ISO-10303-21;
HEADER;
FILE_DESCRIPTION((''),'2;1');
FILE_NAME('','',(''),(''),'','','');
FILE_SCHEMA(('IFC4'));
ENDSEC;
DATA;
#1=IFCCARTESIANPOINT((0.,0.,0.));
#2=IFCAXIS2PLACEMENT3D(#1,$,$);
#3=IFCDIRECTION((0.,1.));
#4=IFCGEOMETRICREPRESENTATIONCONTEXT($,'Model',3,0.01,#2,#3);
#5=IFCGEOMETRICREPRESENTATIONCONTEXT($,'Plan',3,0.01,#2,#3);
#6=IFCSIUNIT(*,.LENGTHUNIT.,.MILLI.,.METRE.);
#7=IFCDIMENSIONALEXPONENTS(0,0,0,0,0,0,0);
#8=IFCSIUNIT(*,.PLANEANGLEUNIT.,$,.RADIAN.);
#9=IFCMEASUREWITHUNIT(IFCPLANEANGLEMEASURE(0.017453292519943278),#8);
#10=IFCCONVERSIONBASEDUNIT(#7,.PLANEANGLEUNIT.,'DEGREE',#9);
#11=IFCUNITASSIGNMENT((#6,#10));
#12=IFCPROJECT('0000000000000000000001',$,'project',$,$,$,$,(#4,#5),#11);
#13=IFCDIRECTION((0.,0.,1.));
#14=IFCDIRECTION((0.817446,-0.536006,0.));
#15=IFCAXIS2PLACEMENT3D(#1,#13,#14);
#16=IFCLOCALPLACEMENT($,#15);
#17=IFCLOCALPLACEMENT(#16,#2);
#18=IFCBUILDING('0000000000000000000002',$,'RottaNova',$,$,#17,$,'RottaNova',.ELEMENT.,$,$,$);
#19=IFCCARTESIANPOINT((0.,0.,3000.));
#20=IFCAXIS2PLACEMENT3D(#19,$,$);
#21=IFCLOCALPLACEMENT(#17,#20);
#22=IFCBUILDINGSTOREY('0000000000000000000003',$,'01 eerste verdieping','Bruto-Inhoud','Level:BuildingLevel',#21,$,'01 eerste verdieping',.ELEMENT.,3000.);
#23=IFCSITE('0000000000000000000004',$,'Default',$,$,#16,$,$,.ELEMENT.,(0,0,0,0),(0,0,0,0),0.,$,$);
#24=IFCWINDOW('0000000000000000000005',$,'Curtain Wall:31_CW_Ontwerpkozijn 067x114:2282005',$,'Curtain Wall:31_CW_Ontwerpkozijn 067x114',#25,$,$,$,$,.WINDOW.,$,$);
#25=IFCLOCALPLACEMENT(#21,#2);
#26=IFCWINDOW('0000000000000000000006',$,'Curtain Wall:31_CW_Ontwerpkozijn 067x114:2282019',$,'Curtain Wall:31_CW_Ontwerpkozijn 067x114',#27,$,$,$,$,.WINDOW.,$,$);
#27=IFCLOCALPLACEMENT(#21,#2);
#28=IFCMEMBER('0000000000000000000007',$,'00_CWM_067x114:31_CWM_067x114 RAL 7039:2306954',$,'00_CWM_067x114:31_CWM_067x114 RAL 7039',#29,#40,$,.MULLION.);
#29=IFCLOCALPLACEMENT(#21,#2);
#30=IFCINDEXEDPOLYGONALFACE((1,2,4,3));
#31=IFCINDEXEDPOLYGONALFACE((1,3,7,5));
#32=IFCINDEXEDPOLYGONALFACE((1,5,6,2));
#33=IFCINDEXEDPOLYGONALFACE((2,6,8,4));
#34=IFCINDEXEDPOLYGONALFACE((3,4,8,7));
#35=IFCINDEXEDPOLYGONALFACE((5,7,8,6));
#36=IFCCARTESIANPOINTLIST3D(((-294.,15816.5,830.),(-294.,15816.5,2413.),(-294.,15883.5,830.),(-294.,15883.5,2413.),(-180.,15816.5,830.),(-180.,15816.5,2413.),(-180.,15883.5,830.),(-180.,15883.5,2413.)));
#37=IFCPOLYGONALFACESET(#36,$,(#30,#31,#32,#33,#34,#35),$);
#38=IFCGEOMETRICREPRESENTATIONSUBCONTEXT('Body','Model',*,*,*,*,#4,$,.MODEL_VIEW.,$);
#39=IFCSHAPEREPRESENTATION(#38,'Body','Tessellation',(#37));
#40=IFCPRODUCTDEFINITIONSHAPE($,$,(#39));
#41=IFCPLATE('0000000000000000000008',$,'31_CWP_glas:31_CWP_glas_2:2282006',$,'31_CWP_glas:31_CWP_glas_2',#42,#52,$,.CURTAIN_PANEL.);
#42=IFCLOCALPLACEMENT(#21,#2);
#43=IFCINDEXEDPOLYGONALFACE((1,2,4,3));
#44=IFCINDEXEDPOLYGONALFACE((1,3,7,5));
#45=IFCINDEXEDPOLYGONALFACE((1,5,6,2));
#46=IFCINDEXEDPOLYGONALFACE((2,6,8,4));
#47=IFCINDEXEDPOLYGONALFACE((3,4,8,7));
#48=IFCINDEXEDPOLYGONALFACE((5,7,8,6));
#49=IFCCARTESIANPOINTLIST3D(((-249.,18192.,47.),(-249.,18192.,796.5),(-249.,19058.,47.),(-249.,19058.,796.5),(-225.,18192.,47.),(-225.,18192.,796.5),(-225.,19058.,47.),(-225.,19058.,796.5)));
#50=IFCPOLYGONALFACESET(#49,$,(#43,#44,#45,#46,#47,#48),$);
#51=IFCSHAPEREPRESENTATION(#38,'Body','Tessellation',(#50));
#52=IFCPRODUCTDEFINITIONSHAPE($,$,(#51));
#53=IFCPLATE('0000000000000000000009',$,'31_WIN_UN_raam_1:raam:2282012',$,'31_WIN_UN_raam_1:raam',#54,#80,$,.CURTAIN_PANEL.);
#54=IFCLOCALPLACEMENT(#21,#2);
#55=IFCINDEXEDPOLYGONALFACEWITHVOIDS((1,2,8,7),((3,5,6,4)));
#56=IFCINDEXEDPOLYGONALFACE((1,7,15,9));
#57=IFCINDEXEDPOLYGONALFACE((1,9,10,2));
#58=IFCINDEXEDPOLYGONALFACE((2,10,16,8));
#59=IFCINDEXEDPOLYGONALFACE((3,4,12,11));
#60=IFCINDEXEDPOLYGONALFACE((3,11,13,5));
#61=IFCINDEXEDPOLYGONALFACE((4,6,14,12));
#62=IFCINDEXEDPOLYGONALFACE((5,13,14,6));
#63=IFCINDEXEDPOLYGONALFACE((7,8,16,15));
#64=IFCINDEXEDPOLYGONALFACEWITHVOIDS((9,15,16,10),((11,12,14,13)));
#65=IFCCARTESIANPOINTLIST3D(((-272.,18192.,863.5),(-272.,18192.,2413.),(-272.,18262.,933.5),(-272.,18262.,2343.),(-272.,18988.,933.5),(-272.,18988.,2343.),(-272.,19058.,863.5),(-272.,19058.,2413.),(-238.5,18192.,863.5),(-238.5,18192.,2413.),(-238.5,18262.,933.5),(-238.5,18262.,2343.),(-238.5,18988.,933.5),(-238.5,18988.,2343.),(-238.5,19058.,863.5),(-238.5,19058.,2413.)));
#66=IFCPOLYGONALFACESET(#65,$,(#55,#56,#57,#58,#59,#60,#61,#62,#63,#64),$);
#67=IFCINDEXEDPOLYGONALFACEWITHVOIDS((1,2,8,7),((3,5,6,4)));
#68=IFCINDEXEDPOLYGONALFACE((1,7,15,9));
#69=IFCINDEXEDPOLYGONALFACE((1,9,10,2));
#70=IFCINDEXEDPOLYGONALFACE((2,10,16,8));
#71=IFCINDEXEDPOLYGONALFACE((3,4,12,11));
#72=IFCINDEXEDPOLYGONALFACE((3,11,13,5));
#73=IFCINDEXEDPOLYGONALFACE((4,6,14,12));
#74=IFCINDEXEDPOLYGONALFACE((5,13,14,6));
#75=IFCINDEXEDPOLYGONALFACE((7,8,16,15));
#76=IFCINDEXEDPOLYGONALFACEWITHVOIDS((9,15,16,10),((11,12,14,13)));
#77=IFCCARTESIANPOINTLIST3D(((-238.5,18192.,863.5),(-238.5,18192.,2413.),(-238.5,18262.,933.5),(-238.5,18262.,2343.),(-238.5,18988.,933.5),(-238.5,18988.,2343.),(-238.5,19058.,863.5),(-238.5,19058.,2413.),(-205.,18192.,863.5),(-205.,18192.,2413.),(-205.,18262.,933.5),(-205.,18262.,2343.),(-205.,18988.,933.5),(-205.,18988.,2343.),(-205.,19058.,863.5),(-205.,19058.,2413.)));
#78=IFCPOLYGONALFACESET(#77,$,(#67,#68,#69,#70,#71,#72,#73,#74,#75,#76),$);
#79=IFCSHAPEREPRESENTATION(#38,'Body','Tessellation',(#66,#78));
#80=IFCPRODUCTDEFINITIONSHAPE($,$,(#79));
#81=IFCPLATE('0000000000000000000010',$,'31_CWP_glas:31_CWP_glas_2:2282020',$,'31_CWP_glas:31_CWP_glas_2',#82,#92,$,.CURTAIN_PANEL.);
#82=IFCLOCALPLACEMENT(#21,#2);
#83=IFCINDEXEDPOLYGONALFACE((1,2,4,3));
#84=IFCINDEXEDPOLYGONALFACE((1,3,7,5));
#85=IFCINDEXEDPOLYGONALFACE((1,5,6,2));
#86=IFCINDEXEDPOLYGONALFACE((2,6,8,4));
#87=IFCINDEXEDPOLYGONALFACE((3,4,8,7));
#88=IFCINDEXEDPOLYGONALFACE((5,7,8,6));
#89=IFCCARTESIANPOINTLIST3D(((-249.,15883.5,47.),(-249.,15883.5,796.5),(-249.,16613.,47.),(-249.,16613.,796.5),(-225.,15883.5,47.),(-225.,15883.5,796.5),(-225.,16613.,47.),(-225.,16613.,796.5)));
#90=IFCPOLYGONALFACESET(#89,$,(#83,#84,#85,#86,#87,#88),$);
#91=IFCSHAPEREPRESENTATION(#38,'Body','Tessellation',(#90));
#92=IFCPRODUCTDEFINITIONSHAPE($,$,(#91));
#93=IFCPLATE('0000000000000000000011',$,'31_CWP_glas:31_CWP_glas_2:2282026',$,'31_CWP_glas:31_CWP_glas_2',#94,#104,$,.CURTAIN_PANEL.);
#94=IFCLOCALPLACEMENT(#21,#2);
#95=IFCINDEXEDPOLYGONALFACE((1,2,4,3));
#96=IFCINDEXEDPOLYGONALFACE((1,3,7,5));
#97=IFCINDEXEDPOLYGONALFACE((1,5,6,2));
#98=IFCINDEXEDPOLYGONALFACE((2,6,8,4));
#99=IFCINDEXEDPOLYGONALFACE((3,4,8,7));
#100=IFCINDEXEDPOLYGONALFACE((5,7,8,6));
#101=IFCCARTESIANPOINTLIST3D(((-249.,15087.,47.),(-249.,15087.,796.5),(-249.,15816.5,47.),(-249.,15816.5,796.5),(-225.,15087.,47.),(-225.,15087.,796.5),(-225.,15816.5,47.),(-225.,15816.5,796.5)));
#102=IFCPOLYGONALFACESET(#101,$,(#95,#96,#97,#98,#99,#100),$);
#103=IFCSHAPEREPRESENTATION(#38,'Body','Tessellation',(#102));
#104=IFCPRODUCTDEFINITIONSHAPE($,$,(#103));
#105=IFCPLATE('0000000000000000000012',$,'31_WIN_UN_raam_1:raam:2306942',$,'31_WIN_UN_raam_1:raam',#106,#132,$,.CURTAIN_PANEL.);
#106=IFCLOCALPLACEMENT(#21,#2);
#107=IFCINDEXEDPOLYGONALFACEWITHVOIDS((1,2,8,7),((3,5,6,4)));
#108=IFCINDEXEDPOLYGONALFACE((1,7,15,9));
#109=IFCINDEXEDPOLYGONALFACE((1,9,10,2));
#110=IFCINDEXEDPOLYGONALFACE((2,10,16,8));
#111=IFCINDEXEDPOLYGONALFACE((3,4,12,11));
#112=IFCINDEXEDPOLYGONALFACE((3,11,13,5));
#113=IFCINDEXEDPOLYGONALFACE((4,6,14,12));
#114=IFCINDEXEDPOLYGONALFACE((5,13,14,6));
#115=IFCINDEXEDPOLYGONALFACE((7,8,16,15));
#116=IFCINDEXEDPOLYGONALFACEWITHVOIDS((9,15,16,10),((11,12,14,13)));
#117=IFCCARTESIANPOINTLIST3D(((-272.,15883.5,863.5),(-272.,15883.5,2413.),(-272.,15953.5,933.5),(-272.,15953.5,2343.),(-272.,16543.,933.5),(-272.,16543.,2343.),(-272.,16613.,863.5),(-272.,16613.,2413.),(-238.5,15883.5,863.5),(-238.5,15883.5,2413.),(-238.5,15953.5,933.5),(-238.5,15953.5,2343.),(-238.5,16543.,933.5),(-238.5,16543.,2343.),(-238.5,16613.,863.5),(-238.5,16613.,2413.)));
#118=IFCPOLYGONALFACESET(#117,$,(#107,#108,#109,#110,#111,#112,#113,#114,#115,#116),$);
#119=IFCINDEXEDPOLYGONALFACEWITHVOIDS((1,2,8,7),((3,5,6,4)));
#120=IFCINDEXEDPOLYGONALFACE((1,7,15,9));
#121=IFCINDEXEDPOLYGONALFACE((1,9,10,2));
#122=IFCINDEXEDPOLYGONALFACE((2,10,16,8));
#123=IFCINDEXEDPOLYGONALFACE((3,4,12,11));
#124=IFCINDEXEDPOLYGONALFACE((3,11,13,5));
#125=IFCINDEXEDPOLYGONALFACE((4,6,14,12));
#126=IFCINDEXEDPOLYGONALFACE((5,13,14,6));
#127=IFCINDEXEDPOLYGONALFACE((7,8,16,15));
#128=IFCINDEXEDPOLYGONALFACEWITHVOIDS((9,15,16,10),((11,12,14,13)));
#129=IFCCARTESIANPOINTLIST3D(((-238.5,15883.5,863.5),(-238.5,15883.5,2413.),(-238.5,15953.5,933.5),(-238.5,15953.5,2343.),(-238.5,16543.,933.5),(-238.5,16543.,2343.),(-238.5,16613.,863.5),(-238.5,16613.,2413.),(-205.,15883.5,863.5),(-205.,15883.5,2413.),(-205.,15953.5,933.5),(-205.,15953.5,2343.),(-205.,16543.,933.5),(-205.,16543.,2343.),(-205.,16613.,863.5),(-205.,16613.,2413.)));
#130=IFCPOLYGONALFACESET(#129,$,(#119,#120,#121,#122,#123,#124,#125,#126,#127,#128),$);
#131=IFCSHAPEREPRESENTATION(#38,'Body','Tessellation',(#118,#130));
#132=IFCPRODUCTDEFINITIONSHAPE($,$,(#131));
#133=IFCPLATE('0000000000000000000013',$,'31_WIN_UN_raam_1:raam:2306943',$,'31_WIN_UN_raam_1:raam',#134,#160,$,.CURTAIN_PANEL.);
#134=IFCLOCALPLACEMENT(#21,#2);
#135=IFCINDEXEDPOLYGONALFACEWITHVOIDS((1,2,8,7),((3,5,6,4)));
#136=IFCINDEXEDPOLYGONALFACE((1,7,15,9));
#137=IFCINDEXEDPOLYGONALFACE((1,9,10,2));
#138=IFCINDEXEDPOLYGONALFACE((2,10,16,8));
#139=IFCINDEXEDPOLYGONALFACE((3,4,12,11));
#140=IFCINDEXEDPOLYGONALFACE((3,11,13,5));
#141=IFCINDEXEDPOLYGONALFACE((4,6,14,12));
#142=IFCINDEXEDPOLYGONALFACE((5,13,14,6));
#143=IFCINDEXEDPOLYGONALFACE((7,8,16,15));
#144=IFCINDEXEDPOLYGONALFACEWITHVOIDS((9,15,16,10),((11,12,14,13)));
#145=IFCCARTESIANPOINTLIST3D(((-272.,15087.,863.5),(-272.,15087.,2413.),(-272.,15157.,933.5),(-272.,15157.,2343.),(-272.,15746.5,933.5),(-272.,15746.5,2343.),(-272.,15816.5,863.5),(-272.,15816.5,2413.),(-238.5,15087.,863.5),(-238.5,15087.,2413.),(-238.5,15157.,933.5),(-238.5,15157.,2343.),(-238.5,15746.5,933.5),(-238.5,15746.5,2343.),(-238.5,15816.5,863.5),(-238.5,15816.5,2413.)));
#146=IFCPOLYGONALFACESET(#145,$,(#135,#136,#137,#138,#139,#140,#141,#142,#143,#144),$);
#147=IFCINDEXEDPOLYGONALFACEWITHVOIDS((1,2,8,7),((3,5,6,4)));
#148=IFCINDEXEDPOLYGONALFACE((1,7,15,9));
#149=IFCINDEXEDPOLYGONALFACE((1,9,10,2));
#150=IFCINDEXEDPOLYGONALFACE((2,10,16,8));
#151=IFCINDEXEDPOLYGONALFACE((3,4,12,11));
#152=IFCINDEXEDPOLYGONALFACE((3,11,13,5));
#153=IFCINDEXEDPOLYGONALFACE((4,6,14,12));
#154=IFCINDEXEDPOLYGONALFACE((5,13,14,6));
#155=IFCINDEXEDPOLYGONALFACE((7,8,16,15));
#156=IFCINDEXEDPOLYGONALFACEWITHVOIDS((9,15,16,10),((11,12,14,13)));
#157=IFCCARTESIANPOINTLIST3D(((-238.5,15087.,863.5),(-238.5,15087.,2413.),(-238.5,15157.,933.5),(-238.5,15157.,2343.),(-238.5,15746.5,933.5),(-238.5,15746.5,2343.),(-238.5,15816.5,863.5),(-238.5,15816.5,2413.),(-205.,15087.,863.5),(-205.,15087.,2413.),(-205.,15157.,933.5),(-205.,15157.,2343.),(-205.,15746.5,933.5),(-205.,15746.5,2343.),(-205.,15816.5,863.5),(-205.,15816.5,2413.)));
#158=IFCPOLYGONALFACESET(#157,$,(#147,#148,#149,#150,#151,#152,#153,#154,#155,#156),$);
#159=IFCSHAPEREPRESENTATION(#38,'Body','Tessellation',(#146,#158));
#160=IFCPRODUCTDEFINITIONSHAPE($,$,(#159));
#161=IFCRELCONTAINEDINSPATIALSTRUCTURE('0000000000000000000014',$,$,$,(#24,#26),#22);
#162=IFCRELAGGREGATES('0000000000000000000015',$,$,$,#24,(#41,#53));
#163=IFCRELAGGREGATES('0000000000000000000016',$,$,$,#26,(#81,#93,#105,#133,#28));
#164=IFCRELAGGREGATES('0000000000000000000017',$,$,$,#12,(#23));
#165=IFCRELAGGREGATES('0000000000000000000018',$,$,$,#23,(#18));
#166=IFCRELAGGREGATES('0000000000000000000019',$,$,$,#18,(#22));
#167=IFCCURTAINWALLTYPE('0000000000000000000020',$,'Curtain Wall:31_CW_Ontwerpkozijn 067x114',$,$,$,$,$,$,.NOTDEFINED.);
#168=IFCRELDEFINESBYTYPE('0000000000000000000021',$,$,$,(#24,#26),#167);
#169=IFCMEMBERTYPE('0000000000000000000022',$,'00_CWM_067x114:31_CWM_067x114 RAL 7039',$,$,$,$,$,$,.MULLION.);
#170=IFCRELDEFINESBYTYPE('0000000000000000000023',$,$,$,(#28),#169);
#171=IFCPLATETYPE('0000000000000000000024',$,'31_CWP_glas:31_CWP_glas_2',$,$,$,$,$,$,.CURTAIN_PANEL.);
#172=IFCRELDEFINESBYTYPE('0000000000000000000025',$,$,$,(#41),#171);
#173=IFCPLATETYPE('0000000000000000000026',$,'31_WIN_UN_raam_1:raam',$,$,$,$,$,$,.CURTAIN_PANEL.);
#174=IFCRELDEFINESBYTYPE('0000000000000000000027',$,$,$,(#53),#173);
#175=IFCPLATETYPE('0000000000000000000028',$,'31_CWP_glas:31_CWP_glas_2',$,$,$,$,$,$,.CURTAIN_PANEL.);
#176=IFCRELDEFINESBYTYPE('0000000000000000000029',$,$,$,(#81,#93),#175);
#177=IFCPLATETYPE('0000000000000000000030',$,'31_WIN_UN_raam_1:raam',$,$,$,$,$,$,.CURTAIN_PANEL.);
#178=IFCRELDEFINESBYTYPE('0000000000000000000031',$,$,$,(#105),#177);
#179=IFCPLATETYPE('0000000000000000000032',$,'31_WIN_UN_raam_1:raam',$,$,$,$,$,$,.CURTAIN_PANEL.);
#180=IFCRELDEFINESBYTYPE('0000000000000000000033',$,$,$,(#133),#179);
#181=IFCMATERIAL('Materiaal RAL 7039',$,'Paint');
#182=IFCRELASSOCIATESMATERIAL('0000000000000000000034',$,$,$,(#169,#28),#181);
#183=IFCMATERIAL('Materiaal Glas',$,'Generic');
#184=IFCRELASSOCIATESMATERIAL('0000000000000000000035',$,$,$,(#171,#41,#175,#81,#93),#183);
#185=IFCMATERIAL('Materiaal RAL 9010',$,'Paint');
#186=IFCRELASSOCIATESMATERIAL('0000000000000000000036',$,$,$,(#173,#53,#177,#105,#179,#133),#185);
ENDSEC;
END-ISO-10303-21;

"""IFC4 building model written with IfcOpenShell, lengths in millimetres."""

from ifc_helpers import new_model, entity, si_unit, converted_unit, direction, frame, origin, place, context, subcontext, project, spatial, indexed_curve, outline, extrude, source, transform, mapped, material, type_object, type_shapes, element, aggregate, save


model = new_model("IFC4")

# Units and contexts
model_context = context("Model", 3, precision=0.01, world=origin(), true_north=direction((0.0, 1.0)))
plan_context = context("Plan", 3, precision=0.01, world=origin(), true_north=direction((0.0, 1.0)))
body_context = subcontext(model_context, "Body", "Model", "MODEL_VIEW")
ifc_project = project(units=[si_unit("LENGTHUNIT", "METRE", prefix="MILLI"), converted_unit("PLANEANGLEUNIT", "DEGREE", entity("IfcPlaneAngleMeasure", 0.017453292519943278), si_unit("PLANEANGLEUNIT", "RADIAN"), dimensions=[0, 0, 0, 0, 0, 0, 0])], contexts=[model_context, plan_context])

# Site, building, storey
site_placement = place(None, frame((0.0, 0.0, 0.0), z_axis=(0.0, 0.0, 1.0), x_axis=(0.817446, -0.536006, 0.0)))
site = spatial("IfcSite", under=ifc_project, at=site_placement, Name="Default", CompositionType="ELEMENT", RefLatitude=(0, 0, 0, 0), RefLongitude=(0, 0, 0, 0), RefElevation=0.0)
building_placement = place(site_placement, origin())
building = spatial("IfcBuilding", under=site, at=building_placement, Name="RottaNova", LongName="RottaNova", CompositionType="ELEMENT")
storey_placement = place(building_placement, frame((0.0, 0.0, 3000.0)))
storey = spatial("IfcBuildingStorey", under=building, at=storey_placement, Name="01 eerste verdieping", Description="Bruto-Inhoud", ObjectType="Level:BuildingLevel", LongName="01 eerste verdieping", CompositionType="ELEMENT", Elevation=3000.0)

# Windows, member
curtain_wall_type = type_object("IfcCurtainWallType", Name="Curtain Wall:31_CW_Ontwerpkozijn 067x114", PredefinedType="NOTDEFINED")
window_1_placement = place(storey_placement, frame((0.0, 0.0, -3000.0)))
window_1 = element("IfcWindow", 1, at=window_1_placement, inside=storey, type_object=curtain_wall_type, Name="Curtain Wall:31_CW_Ontwerpkozijn 067x114:2282005", ObjectType="Curtain Wall:31_CW_Ontwerpkozijn 067x114", PredefinedType="WINDOW")
ifc_material_1 = material(Name="Materiaal RAL 7039", Category="Paint")
window_2_placement = place(storey_placement, frame((0.0, 0.0, -3000.0)))
window_2 = element("IfcWindow", 2, at=window_2_placement, inside=storey, type_object=curtain_wall_type, Name="Curtain Wall:31_CW_Ontwerpkozijn 067x114:2282019", ObjectType="Curtain Wall:31_CW_Ontwerpkozijn 067x114", PredefinedType="WINDOW")
member_type_1 = type_object("IfcMemberType", Name="00_CWM_067x114:31_CWM_067x114 RAL 7039", PredefinedType="MULLION", material=ifc_material_1)
shared_shape_1 = source(origin(), body_context, "Body", "SweptSolid", [
    extrude(outline(indexed_curve([(-33.5, -57.0), (33.5, -57.0), (33.5, 57.0), (-33.5, 57.0), (-33.5, -57.0)], self_intersect=False)), frame((0.0, 57.0, -1583.0), z_axis=(0.0, 0.0, 1.0), x_axis=(-1.0, 0.0, 0.0)), (0.0, 0.0, 1.0), 1583.0),
])
type_shapes(member_type_1, [shared_shape_1])
member_1_placement = place(window_2_placement, frame((-180.0, 15850.0, 3830.0), z_axis=(0.0, 0.0, -1.0), x_axis=(0.0, -1.0, 0.0)))
member_1 = element("IfcMember", 3, at=member_1_placement, type_object=member_type_1, material=ifc_material_1, Name="00_CWM_067x114:31_CWM_067x114 RAL 7039:2306954", ObjectType="00_CWM_067x114:31_CWM_067x114 RAL 7039", PredefinedType="MULLION", context=body_context, shape_type="MappedRepresentation", body=[
    mapped(shared_shape_1, transform((0.0, 0.0, 0.0), scale=1.0)),
])

# Plates
ifc_material_2 = material(Name="Materiaal Glas", Category="Generic")
plate_type_1 = type_object("IfcPlateType", Name="31_CWP_glas:31_CWP_glas_2", PredefinedType="CURTAIN_PANEL", material=ifc_material_2)
shared_shape_2 = source(origin(), body_context, "Body", "SweptSolid", [
    extrude(outline(indexed_curve([(-12.0, -433.0), (12.0, -433.0), (12.0, 433.0), (-12.0, 433.0), (-12.0, -433.0)], self_intersect=False)), frame((0.0, 57.0, 0.0), z_axis=(0.0, 0.0, 1.0), x_axis=(0.0, 1.0, 0.0)), (0.0, 0.0, 1.0), 749.5),
])
type_shapes(plate_type_1, [shared_shape_2])
plate_1_placement = place(window_1_placement, frame((-180.0, 18625.0, 3047.0), z_axis=(0.0, 0.0, 1.0), x_axis=(0.0, 1.0, 0.0)))
plate_1 = element("IfcPlate", 4, at=plate_1_placement, type_object=plate_type_1, material=ifc_material_2, Name="31_CWP_glas:31_CWP_glas_2:2282006", ObjectType="31_CWP_glas:31_CWP_glas_2", PredefinedType="CURTAIN_PANEL", context=body_context, shape_type="MappedRepresentation", body=[
    mapped(shared_shape_2, transform((0.0, 0.0, 0.0), scale=1.0)),
])
ifc_material_3 = material(Name="Materiaal RAL 9010", Category="Paint")
plate_type_2 = type_object("IfcPlateType", Name="31_WIN_UN_raam_1:raam", PredefinedType="CURTAIN_PANEL", material=ifc_material_3)
shared_shape_3 = source(origin(), body_context, "Body", "SweptSolid", [
    extrude(outline(indexed_curve([(-433.0, -774.7), (433.0, -774.7), (433.0, 774.7), (-433.0, 774.7), (-433.0, -774.7)], self_intersect=False), holes=[indexed_curve([(-363.0, 704.7), (363.0, 704.7), (363.0, -704.8), (-363.0, -704.8), (-363.0, 704.7)], self_intersect=False)]), frame((0.0, 58.5, 774.8), z_axis=(0.0, 1.0, 0.0), x_axis=(1.0, 0.0, 0.0)), (0.0, 0.0, 1.0), 33.5),
    extrude(outline(indexed_curve([(-433.0, -774.7), (433.0, -774.7), (433.0, 774.7), (-433.0, 774.7), (-433.0, -774.7)], self_intersect=False), holes=[indexed_curve([(-363.0, 704.7), (363.0, 704.7), (363.0, -704.8), (-363.0, -704.8), (-363.0, 704.7)], self_intersect=False)]), frame((0.0, 25.0, 774.8), z_axis=(0.0, 1.0, 0.0), x_axis=(1.0, 0.0, 0.0)), (0.0, 0.0, 1.0), 33.5),
])
type_shapes(plate_type_2, [shared_shape_3])
plate_2_placement = place(window_1_placement, frame((-180.0, 18625.0, 3863.5), z_axis=(0.0, 0.0, 1.0), x_axis=(0.0, 1.0, 0.0)))
plate_2 = element("IfcPlate", 5, at=plate_2_placement, type_object=plate_type_2, material=ifc_material_3, Name="31_WIN_UN_raam_1:raam:2282012", ObjectType="31_WIN_UN_raam_1:raam", PredefinedType="CURTAIN_PANEL", context=body_context, shape_type="MappedRepresentation", body=[
    mapped(shared_shape_3, transform((0.0, 0.0, 0.0), scale=1.0)),
])
aggregate(window_1, [plate_1, plate_2])
plate_type_3 = type_object("IfcPlateType", Name="31_CWP_glas:31_CWP_glas_2", PredefinedType="CURTAIN_PANEL", material=ifc_material_2)
shared_shape_4 = source(origin(), body_context, "Body", "SweptSolid", [
    extrude(outline(indexed_curve([(-12.0, -364.7), (12.0, -364.7), (12.0, 364.7), (-12.0, 364.7), (-12.0, -364.7)], self_intersect=False)), frame((0.0, -57.0, 0.0), z_axis=(0.0, 0.0, 1.0), x_axis=(0.0, 1.0, 0.0)), (0.0, 0.0, 1.0), 749.5),
])
type_shapes(plate_type_3, [shared_shape_4])
plate_3_placement = place(window_2_placement, frame((-180.0, 16248.2, 3047.0), z_axis=(0.0, 0.0, 1.0), x_axis=(0.0, -1.0, 0.0)))
plate_3 = element("IfcPlate", 6, at=plate_3_placement, type_object=plate_type_3, material=ifc_material_2, Name="31_CWP_glas:31_CWP_glas_2:2282020", ObjectType="31_CWP_glas:31_CWP_glas_2", PredefinedType="CURTAIN_PANEL", context=body_context, shape_type="MappedRepresentation", body=[
    mapped(shared_shape_4, transform((0.0, 0.0, 0.0), scale=1.0)),
])
plate_4_placement = place(window_2_placement, frame((-180.0, 15451.7, 3047.0), z_axis=(0.0, 0.0, 1.0), x_axis=(0.0, -1.0, 0.0)))
plate_4 = element("IfcPlate", 7, at=plate_4_placement, type_object=plate_type_3, material=ifc_material_2, Name="31_CWP_glas:31_CWP_glas_2:2282026", ObjectType="31_CWP_glas:31_CWP_glas_2", PredefinedType="CURTAIN_PANEL", context=body_context, shape_type="MappedRepresentation", body=[
    mapped(shared_shape_4, transform((0.0, 0.0, 0.0), scale=1.0)),
])
plate_type_4 = type_object("IfcPlateType", Name="31_WIN_UN_raam_1:raam", PredefinedType="CURTAIN_PANEL", material=ifc_material_3)
shared_shape_5 = source(origin(), body_context, "Body", "SweptSolid", [
    extrude(outline(indexed_curve([(-364.7, -774.7), (364.7, -774.7), (364.7, 774.7), (-364.7, 774.7), (-364.7, -774.7)], self_intersect=False), holes=[indexed_curve([(-294.7, 704.7), (294.7, 704.7), (294.7, -704.8), (-294.7, -704.8), (-294.7, 704.7)], self_intersect=False)]), frame((0.0, -92.0, 774.8), z_axis=(0.0, 1.0, 0.0), x_axis=(1.0, 0.0, 0.0)), (0.0, 0.0, 1.0), 33.5),
    extrude(outline(indexed_curve([(-364.7, -774.7), (364.7, -774.7), (364.7, 774.7), (-364.7, 774.7), (-364.7, -774.7)], self_intersect=False), holes=[indexed_curve([(-294.7, 704.7), (294.7, 704.7), (294.7, -704.8), (-294.7, -704.8), (-294.7, 704.7)], self_intersect=False)]), frame((0.0, -58.5, 774.8), z_axis=(0.0, 1.0, 0.0), x_axis=(1.0, 0.0, 0.0)), (0.0, 0.0, 1.0), 33.5),
])
type_shapes(plate_type_4, [shared_shape_5])
plate_5_placement = place(window_2_placement, frame((-180.0, 16248.2, 3863.5), z_axis=(0.0, 0.0, 1.0), x_axis=(0.0, -1.0, 0.0)))
plate_5 = element("IfcPlate", 8, at=plate_5_placement, type_object=plate_type_4, material=ifc_material_3, Name="31_WIN_UN_raam_1:raam:2306942", ObjectType="31_WIN_UN_raam_1:raam", PredefinedType="CURTAIN_PANEL", context=body_context, shape_type="MappedRepresentation", body=[
    mapped(shared_shape_5, transform((0.0, 0.0, 0.0), scale=1.0)),
])
plate_type_5 = type_object("IfcPlateType", Name="31_WIN_UN_raam_1:raam", PredefinedType="CURTAIN_PANEL", material=ifc_material_3)
shared_shape_6 = source(origin(), body_context, "Body", "SweptSolid", [
    extrude(outline(indexed_curve([(-364.7, -774.7), (364.7, -774.7), (364.7, 774.7), (-364.7, 774.7), (-364.7, -774.7)], self_intersect=False), holes=[indexed_curve([(-294.7, 704.7), (294.7, 704.7), (294.7, -704.8), (-294.7, -704.8), (-294.7, 704.7)], self_intersect=False)]), frame((0.0, -92.0, 774.8), z_axis=(0.0, 1.0, 0.0), x_axis=(1.0, 0.0, 0.0)), (0.0, 0.0, 1.0), 33.5),
    extrude(outline(indexed_curve([(-364.7, -774.7), (364.7, -774.7), (364.7, 774.7), (-364.7, 774.7), (-364.7, -774.7)], self_intersect=False), holes=[indexed_curve([(-294.7, 704.7), (294.7, 704.7), (294.7, -704.8), (-294.7, -704.8), (-294.7, 704.7)], self_intersect=False)]), frame((0.0, -58.5, 774.8), z_axis=(0.0, 1.0, 0.0), x_axis=(1.0, 0.0, 0.0)), (0.0, 0.0, 1.0), 33.5),
])
type_shapes(plate_type_5, [shared_shape_6])
plate_6_placement = place(window_2_placement, frame((-180.0, 15451.7, 3863.5), z_axis=(0.0, 0.0, 1.0), x_axis=(0.0, -1.0, 0.0)))
plate_6 = element("IfcPlate", 9, at=plate_6_placement, type_object=plate_type_5, material=ifc_material_3, Name="31_WIN_UN_raam_1:raam:2306943", ObjectType="31_WIN_UN_raam_1:raam", PredefinedType="CURTAIN_PANEL", context=body_context, shape_type="MappedRepresentation", body=[
    mapped(shared_shape_6, transform((0.0, 0.0, 0.0), scale=1.0)),
])
aggregate(window_2, [plate_3, plate_4, plate_5, plate_6, member_1])

save(model, "model.ifc")
